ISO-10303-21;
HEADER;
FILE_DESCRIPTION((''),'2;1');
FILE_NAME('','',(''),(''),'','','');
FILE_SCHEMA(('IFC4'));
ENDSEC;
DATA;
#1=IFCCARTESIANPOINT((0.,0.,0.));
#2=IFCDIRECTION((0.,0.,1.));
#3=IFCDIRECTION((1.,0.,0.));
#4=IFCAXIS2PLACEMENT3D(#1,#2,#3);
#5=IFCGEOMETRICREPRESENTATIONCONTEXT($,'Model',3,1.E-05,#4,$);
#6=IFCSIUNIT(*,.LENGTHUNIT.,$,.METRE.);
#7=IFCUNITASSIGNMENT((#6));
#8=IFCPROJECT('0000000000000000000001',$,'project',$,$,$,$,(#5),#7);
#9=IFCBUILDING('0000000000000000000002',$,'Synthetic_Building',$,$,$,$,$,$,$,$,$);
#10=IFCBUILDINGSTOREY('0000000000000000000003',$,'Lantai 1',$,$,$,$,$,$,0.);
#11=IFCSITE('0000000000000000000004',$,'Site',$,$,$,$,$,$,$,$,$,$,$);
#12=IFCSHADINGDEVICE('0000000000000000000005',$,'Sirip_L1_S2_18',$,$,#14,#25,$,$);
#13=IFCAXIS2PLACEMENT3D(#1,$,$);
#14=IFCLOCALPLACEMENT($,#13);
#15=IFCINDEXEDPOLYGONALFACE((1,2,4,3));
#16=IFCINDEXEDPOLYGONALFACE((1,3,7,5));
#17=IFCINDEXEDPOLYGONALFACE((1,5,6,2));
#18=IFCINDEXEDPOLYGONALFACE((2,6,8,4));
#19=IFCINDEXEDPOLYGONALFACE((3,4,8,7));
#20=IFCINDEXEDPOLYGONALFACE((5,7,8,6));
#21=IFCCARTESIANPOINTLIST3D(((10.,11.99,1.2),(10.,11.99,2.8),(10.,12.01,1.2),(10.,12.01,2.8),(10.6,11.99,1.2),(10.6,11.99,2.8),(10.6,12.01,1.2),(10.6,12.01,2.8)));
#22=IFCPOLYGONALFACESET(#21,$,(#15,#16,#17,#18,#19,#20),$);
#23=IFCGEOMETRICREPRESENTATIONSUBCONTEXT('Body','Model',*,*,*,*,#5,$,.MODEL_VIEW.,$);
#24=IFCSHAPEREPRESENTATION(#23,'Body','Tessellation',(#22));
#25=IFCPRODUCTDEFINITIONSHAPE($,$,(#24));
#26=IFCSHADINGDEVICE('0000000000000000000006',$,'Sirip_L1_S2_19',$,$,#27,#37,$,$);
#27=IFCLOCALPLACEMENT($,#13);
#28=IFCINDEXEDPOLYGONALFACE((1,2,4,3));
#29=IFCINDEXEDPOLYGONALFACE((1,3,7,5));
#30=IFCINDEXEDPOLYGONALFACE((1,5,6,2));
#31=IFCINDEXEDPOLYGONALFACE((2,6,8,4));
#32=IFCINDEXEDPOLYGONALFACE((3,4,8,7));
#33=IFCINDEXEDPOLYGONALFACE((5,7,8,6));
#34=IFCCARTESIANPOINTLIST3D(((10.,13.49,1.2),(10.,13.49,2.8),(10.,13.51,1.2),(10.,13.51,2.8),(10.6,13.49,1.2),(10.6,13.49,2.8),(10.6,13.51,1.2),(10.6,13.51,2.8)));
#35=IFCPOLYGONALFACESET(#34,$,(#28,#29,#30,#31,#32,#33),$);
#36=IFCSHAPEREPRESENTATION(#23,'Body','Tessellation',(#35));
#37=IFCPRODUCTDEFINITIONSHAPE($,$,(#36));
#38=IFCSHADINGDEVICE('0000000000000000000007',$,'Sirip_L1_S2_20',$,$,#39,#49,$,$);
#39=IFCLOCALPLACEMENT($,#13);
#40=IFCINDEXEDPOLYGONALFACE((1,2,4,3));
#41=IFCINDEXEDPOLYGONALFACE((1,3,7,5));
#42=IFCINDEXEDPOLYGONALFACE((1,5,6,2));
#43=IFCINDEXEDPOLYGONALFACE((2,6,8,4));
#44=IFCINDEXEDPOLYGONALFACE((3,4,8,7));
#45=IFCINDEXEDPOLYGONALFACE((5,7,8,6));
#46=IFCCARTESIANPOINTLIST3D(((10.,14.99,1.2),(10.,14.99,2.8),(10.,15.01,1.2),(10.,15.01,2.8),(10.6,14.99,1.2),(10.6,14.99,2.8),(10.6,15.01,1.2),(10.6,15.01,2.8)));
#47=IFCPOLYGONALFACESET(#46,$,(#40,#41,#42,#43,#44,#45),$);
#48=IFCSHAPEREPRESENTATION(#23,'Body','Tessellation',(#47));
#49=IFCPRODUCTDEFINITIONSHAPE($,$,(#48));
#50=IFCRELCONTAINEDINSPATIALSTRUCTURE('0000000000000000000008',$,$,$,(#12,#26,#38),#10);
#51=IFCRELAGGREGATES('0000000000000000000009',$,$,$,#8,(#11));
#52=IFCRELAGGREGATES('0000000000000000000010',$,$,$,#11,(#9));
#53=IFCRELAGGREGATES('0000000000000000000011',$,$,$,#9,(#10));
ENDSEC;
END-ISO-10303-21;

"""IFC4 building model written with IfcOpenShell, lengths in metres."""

from ifc_helpers import new_model, si_unit, frame, origin_with_axes, place, context, subcontext, project, spatial, polyline, outline, extrude, element, save


model = new_model("IFC4")

# Units and contexts
model_context = context("Model", 3, precision=1e-05, world=origin_with_axes())
body_context = subcontext(model_context, "Body", "Model", "MODEL_VIEW")
ifc_project = project(units=[si_unit("LENGTHUNIT", "METRE")], contexts=[model_context])

# Site, building, storey
site = spatial("IfcSite", under=ifc_project, Name="Site")
building = spatial("IfcBuilding", under=site, Name="Synthetic_Building")
storey = spatial("IfcBuildingStorey", under=building, Name="Lantai 1", Elevation=0.0)

# Shading devices
shading_device_1_placement = place(None, origin_with_axes())
element("IfcShadingDevice", 1, at=shading_device_1_placement, inside=storey, Name="Sirip_L1_S2_18", context=body_context, shape_type="SweptSolid", body=[
    extrude(outline(polyline([(10.0, 11.99), (10.0, 12.01), (10.6, 12.01), (10.6, 11.99), (10.0, 11.99)])), frame((0.0, 0.0, 1.2), z_axis=(0.0, 0.0, 1.0), x_axis=(1.0, 0.0, 0.0)), (0.0, 0.0, 1.0), 1.6),
])
shading_device_2_placement = place(None, origin_with_axes())
element("IfcShadingDevice", 2, at=shading_device_2_placement, inside=storey, Name="Sirip_L1_S2_19", context=body_context, shape_type="SweptSolid", body=[
    extrude(outline(polyline([(10.0, 13.49), (10.0, 13.51), (10.6, 13.51), (10.6, 13.49), (10.0, 13.49)])), frame((0.0, 0.0, 1.2), z_axis=(0.0, 0.0, 1.0), x_axis=(1.0, 0.0, 0.0)), (0.0, 0.0, 1.0), 1.6),
])
shading_device_3_placement = place(None, origin_with_axes())
element("IfcShadingDevice", 3, at=shading_device_3_placement, inside=storey, Name="Sirip_L1_S2_20", context=body_context, shape_type="SweptSolid", body=[
    extrude(outline(polyline([(10.0, 14.99), (10.0, 15.01), (10.6, 15.01), (10.6, 14.99), (10.0, 14.99)])), frame((0.0, 0.0, 1.2), z_axis=(0.0, 0.0, 1.0), x_axis=(1.0, 0.0, 0.0)), (0.0, 0.0, 1.0), 1.6),
])

save(model, "model.ifc")
